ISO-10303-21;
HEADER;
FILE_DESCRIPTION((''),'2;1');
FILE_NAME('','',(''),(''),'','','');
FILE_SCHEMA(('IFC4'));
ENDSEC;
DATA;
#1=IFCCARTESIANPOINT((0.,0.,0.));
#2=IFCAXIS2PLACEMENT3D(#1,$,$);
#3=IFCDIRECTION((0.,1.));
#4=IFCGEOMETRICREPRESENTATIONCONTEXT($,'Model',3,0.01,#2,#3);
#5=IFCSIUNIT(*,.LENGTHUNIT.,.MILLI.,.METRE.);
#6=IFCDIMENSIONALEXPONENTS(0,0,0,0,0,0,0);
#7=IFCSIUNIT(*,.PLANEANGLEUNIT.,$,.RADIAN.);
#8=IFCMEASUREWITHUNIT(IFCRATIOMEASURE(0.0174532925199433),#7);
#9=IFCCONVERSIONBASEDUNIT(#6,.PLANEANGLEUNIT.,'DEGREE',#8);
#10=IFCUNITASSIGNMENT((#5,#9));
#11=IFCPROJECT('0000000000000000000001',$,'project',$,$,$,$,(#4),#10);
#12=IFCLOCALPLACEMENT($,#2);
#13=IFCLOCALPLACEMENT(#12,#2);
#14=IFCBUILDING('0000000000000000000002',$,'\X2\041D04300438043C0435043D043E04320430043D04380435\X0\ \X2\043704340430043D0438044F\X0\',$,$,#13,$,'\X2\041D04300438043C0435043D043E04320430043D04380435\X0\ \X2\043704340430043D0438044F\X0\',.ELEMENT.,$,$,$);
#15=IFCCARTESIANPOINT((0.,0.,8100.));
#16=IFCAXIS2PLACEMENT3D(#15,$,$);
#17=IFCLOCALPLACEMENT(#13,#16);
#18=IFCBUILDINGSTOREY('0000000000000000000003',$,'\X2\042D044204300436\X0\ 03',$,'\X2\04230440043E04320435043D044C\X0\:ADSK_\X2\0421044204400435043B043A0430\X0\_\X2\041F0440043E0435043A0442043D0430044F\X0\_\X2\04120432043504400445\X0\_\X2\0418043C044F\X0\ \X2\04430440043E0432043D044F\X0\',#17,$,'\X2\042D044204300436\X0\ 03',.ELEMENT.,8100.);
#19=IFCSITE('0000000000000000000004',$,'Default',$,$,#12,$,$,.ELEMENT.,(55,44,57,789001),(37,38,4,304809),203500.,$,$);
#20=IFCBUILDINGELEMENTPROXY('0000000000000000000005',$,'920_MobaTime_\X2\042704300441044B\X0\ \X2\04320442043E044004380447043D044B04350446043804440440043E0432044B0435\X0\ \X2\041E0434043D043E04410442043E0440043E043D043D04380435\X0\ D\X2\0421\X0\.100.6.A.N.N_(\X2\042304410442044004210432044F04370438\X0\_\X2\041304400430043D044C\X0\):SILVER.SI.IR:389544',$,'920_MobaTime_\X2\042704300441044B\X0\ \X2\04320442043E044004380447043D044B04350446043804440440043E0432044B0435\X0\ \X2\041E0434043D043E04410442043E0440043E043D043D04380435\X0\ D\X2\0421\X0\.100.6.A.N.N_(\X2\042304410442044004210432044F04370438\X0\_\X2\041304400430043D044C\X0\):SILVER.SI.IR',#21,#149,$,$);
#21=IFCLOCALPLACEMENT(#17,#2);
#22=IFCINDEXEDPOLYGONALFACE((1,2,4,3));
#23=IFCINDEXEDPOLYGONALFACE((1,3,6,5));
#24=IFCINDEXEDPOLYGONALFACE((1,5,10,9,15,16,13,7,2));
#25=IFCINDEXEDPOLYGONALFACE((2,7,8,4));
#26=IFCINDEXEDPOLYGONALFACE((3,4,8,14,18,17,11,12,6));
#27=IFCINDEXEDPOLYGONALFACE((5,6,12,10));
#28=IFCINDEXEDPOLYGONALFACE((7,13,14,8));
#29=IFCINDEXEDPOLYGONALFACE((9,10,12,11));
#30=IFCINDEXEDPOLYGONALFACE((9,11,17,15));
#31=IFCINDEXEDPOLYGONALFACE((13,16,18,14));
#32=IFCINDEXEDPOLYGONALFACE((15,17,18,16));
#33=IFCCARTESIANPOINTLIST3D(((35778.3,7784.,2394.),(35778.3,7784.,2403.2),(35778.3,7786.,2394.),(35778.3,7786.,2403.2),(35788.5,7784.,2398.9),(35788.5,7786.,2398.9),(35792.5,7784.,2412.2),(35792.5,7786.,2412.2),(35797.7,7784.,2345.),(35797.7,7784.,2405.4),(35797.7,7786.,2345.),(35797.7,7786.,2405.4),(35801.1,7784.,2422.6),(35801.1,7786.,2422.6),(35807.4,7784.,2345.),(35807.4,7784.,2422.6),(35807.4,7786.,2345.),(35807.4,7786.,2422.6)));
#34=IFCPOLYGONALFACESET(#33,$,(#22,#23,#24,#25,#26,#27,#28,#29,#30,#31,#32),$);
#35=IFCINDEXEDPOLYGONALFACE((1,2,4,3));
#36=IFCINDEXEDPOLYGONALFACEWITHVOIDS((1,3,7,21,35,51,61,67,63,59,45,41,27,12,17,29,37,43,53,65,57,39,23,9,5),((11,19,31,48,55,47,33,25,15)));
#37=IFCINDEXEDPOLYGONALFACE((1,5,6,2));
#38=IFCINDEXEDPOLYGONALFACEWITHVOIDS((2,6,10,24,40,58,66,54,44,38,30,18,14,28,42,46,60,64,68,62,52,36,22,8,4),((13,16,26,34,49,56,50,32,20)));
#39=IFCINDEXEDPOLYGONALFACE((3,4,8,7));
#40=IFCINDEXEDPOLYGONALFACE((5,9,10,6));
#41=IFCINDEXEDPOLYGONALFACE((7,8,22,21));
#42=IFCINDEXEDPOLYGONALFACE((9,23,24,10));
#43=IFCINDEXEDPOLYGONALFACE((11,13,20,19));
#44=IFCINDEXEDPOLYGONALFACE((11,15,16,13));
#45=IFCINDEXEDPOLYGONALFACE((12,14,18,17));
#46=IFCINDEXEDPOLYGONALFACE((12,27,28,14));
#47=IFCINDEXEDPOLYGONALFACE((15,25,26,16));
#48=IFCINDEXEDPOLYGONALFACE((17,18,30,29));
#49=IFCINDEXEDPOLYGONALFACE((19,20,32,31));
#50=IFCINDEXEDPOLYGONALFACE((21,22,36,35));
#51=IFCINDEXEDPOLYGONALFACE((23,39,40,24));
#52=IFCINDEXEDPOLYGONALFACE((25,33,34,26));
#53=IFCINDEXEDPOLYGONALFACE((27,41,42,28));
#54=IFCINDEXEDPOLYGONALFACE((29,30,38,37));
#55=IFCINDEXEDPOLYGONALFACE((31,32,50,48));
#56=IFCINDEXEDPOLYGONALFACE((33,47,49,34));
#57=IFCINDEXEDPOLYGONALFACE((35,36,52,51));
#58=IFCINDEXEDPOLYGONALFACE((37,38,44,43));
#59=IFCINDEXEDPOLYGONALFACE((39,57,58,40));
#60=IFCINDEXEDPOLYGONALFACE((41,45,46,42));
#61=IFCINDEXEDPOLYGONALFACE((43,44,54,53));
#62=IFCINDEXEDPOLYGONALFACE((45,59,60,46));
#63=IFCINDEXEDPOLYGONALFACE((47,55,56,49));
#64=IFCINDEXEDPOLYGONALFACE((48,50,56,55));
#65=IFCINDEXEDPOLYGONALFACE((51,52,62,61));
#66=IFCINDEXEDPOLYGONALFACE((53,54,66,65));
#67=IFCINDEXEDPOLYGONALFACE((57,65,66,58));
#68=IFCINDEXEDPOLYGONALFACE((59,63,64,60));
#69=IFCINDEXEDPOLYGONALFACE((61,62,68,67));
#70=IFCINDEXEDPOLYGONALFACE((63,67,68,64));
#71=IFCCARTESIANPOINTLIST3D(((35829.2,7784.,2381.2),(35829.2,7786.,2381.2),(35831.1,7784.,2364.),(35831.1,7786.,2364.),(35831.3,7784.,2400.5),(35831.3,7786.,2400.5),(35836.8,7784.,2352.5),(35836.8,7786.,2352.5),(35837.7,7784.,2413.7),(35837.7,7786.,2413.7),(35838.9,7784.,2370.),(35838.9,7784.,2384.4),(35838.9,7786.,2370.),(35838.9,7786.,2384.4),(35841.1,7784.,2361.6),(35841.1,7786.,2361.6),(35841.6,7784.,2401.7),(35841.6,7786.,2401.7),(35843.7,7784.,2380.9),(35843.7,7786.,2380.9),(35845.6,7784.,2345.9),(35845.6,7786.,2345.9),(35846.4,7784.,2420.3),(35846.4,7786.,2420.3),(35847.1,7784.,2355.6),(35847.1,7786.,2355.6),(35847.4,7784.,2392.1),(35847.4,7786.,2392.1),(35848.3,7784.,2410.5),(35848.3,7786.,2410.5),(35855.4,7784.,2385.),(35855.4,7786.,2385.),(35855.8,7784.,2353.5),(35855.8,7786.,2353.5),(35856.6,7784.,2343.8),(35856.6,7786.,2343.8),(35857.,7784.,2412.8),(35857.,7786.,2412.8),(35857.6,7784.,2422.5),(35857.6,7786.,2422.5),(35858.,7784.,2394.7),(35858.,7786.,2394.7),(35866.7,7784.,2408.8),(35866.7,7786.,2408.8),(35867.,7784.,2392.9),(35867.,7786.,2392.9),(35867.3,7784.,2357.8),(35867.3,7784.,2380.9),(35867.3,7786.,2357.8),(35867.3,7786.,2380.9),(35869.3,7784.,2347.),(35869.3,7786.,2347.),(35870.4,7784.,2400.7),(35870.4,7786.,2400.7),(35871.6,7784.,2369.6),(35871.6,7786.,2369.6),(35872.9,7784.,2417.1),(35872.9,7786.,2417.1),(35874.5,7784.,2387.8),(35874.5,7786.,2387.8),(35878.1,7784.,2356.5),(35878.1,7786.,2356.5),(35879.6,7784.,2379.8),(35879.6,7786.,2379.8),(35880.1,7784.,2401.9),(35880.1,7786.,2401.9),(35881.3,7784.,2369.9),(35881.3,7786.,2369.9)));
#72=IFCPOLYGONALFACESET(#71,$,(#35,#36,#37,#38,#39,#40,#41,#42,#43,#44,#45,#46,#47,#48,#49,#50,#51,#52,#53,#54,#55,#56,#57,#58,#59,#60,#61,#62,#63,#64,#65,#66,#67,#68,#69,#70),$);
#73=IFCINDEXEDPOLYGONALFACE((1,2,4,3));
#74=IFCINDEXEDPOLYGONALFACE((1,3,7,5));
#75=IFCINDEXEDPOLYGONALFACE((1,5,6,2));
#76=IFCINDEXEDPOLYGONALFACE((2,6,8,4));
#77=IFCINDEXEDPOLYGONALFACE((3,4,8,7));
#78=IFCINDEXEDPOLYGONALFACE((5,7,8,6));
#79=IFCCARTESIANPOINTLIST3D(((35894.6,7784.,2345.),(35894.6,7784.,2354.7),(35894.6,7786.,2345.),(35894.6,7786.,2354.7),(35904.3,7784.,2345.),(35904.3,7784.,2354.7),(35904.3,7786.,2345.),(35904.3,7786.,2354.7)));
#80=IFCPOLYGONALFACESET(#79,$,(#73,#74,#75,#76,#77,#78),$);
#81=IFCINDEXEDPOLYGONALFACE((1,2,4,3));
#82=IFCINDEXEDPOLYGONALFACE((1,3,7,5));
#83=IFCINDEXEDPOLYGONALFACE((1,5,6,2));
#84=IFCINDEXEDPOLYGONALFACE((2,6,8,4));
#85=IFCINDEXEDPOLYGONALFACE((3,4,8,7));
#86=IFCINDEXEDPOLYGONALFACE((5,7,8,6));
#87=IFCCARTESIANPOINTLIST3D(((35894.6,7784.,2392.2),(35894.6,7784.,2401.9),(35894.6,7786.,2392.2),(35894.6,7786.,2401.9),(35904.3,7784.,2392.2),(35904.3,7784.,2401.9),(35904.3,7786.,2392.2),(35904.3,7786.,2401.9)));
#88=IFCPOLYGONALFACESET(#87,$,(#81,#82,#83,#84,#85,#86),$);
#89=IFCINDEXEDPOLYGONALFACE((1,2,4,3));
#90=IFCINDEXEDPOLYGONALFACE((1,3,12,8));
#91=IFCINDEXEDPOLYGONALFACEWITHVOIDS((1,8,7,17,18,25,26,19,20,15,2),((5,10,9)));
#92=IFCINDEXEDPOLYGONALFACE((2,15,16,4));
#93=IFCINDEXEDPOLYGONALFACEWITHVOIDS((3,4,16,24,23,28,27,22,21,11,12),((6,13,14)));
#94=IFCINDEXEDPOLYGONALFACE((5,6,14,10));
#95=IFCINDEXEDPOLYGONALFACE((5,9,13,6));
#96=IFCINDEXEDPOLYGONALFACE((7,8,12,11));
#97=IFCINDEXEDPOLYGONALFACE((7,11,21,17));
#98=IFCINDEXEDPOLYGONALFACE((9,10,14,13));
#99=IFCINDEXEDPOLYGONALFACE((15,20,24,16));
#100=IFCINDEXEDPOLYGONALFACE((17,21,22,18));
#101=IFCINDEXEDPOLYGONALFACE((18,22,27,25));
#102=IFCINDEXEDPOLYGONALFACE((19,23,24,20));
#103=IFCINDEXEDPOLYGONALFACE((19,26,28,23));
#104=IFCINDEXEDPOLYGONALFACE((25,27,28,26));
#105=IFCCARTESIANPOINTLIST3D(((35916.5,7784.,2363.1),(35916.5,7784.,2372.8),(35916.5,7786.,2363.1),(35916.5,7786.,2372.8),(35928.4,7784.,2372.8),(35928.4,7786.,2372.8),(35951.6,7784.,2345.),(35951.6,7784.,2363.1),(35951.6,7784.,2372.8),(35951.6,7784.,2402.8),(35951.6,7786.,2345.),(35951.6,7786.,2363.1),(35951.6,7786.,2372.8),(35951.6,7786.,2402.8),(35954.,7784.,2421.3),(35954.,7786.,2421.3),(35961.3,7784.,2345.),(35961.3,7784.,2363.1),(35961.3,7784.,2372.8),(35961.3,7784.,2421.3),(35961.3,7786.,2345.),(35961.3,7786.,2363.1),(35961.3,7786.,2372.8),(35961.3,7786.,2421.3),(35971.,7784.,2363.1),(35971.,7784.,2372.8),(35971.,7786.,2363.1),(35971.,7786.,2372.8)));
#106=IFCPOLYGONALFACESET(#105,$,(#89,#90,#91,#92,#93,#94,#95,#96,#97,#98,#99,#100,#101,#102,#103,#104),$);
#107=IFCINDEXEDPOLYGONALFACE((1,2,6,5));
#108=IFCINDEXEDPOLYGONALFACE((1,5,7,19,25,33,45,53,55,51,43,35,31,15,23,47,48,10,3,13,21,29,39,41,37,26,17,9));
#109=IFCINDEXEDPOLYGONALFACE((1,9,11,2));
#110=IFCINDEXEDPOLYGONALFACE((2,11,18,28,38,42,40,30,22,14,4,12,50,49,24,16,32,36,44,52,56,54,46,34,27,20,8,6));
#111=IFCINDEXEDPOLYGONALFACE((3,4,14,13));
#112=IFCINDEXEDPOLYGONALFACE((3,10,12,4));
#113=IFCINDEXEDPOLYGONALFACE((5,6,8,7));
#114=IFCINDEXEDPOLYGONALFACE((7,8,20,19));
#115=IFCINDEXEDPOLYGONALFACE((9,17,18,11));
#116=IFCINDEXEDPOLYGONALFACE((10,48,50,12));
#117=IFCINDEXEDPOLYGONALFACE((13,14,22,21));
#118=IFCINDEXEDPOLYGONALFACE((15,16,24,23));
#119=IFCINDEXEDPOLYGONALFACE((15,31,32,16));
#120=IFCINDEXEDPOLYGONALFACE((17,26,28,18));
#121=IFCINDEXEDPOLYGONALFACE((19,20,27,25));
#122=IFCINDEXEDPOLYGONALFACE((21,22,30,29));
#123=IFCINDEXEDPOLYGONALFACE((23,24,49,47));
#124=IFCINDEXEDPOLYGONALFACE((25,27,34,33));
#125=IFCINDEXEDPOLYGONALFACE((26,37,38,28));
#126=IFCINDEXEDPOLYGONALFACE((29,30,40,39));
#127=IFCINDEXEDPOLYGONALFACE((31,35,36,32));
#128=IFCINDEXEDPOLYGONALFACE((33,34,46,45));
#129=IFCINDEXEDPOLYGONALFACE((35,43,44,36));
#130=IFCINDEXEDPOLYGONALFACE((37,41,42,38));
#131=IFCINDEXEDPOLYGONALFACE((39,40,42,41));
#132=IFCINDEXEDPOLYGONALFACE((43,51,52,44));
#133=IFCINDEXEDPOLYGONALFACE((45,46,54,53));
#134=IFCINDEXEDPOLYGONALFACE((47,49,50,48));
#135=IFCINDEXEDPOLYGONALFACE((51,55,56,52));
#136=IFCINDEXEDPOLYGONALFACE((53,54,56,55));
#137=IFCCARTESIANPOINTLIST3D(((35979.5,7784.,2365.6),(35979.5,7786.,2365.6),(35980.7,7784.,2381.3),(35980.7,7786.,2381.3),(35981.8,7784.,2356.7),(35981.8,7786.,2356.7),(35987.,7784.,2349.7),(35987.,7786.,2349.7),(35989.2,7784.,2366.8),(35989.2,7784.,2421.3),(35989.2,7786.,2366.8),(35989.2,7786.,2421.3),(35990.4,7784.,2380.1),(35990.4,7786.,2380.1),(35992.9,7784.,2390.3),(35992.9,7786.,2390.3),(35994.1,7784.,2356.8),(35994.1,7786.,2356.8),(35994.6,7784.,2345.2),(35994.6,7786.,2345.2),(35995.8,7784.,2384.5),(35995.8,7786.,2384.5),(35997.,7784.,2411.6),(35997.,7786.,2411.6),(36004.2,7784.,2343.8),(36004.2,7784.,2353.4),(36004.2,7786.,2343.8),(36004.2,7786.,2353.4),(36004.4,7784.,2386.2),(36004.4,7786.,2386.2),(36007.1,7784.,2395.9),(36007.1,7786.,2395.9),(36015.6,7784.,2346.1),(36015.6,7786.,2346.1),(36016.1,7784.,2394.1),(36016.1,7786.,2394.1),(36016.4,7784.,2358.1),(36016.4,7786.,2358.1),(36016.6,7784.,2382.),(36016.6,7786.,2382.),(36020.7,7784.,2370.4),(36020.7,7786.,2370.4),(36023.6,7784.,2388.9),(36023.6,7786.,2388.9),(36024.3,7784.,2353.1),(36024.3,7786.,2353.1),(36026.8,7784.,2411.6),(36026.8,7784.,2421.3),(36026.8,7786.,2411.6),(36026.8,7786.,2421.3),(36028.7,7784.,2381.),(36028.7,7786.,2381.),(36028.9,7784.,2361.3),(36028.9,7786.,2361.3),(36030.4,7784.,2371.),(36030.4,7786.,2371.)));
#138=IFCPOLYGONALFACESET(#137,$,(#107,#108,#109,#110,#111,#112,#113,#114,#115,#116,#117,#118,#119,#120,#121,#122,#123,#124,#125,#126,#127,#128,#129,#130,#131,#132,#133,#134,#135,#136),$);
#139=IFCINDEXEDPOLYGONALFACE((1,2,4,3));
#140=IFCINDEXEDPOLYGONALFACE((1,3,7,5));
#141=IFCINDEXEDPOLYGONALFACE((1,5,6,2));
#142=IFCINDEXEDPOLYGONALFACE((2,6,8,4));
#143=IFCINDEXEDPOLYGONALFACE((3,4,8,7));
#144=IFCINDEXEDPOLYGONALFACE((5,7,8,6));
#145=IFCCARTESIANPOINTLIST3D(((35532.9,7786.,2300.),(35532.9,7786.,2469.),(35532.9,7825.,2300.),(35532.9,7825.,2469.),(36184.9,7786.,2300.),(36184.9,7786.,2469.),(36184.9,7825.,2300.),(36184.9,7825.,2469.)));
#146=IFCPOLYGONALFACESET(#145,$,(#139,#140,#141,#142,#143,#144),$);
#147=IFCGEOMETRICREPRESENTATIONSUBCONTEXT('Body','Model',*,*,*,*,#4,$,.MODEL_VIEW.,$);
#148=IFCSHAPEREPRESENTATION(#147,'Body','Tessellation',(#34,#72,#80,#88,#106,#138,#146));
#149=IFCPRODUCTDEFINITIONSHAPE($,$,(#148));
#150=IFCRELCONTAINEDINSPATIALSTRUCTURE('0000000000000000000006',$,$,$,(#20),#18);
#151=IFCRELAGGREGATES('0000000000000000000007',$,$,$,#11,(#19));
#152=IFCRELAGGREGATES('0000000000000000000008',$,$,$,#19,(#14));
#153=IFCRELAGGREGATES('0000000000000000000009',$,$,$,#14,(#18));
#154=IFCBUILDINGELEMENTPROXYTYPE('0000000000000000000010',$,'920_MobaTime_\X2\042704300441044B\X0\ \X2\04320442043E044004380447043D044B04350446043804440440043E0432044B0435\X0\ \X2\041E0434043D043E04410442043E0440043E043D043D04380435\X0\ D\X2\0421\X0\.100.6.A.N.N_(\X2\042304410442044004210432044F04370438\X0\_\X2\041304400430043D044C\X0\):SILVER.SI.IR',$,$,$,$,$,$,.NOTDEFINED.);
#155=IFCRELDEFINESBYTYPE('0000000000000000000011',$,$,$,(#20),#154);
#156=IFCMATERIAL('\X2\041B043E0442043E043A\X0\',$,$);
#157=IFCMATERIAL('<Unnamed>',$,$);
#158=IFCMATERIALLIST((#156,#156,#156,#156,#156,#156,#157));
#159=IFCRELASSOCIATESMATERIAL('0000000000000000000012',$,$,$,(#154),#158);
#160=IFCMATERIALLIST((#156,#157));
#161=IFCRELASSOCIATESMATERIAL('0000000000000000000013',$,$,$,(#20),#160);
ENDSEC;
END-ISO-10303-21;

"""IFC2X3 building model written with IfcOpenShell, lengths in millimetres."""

from ifc_helpers import new_model, entity, si_unit, converted_unit, direction, frame, origin, origin_2d_with_axis, place, context, subcontext, project, spatial, polyline, rectangle, outline, extrude, source, transform, mapped, material, material_list, type_object, type_shapes, element, save


model = new_model("IFC2X3")

# Units and contexts
model_context = context("Model", 3, precision=0.01, world=origin(), true_north=direction((0.0, 1.0)))
body_context = subcontext(model_context, "Body", "Model", "MODEL_VIEW")
ifc_project = project(units=[si_unit("LENGTHUNIT", "METRE", prefix="MILLI"), converted_unit("PLANEANGLEUNIT", "DEGREE", entity("IfcRatioMeasure", 0.0174532925199433), si_unit("PLANEANGLEUNIT", "RADIAN"), dimensions=[0, 0, 0, 0, 0, 0, 0])], contexts=[model_context])

# Site, building, storey
site_placement = place(None, origin())
site = spatial("IfcSite", under=ifc_project, at=site_placement, Name="Default", CompositionType="ELEMENT", RefLatitude=(55, 44, 57, 789001), RefLongitude=(37, 38, 4, 304809), RefElevation=203500.0)
building_placement = place(site_placement, origin())
building = spatial("IfcBuilding", under=site, at=building_placement, Name="Наименование здания", LongName="Наименование здания", CompositionType="ELEMENT")
storey_placement = place(building_placement, frame((0.0, 0.0, 8100.0)))
storey = spatial("IfcBuildingStorey", under=building, at=storey_placement, Name="Этаж 03", ObjectType="Уровень:ADSK_Стрелка_Проектная_Вверх_Имя уровня", LongName="Этаж 03", CompositionType="ELEMENT", Elevation=8100.0)

# Building element proxy
ifc_material_1 = material(Name="Лоток")
ifc_material_2 = material(Name="<Unnamed>")
ifc_material_list_1 = material_list([ifc_material_1, ifc_material_1, ifc_material_1, ifc_material_1, ifc_material_1, ifc_material_1, ifc_material_2])
building_element_proxy_type = type_object("IfcBuildingElementProxyType", Name="920_MobaTime_Часы вторичныецифровые Односторонние DС.100.6.A.N.N_(УстрСвязи_Грань):SILVER.SI.IR", PredefinedType="NOTDEFINED", material=ifc_material_list_1)
shared_shape = source(origin(), body_context, "Body", "SweptSolid", [
    extrude(outline(polyline([(-49.3, -13.1), (28.2, -13.1), (28.2, -6.8), (17.9, 1.8), (8.8, 16.0), (-0.3, 16.0), (4.6, 5.8), (11.1, -3.4), (-49.3, -3.4), (-49.3, -13.1)])), frame((-64.6, 9.8, 39.0), z_axis=(0.0, 0.0, 1.0), x_axis=(0.0, 1.0, 0.0)), (0.0, 0.0, 1.0), 2.0),
    extrude(outline(polyline([(2.2, -27.6), (19.0, -27.6), (30.5, -16.1), (33.3, -4.9), (31.0, 5.8), (21.8, 17.2), (5.2, 27.3), (-11.1, 33.0), (-24.0, 32.7), (-33.6, 27.6), (-40.3, 18.6), (-42.8, 5.7), (-38.0, -6.3), (-27.2, -14.9), (-17.5, -17.7), (-8.2, -16.4), (-0.3, -11.9), (5.1, -4.5), (7.3, 6.2), (4.0, 17.2), (18.4, 7.3), (23.6, -2.4), (22.0, -11.4), (14.2, -18.4), (5.3, -18.3), (2.2, -27.6)]), holes=[polyline([(-9.0, 23.3), (-1.3, 14.3), (-2.5, 2.0), (-11.4, -7.0), (-23.4, -6.0), (-32.2, 2.9), (-31.2, 15.1), (-25.6, 22.1), (-17.5, 24.9), (-9.0, 23.3)])]), frame((-2.7, 3.6, 39.0), z_axis=(0.0, 0.0, 1.0), x_axis=(-0.427649, 0.903945, 0.0)), (0.0, 0.0, 1.0), 2.0),
    extrude(rectangle(XDim=9.7, YDim=9.7, at=origin_2d_with_axis()), frame((40.6, -34.7, 39.0)), (0.0, 0.0, 1.0), 2.0),
    extrude(rectangle(XDim=9.7, YDim=9.7, at=origin_2d_with_axis()), frame((40.6, 12.6, 39.0)), (0.0, 0.0, 1.0), 2.0),
    extrude(outline(polyline([(-0.9, -28.1), (8.8, -28.1), (8.8, -9.9), (18.5, -9.9), (18.5, -0.2), (8.8, -0.2), (8.8, 48.3), (1.5, 48.3), (-36.0, -0.2), (-36.0, -9.9), (-0.9, -9.9), (-0.9, -28.1)]), holes=[polyline([(-0.9, -0.2), (-24.1, -0.2), (-0.9, 29.7), (-0.9, -0.2)])]), frame((93.6, -11.4, 39.0)), (0.0, 0.0, 1.0), 2.0),
    extrude(outline(polyline([(3.3, -28.3), (12.5, -28.3), (20.5, -25.0), (26.8, -18.9), (30.7, -10.0), (31.4, 1.6), (26.9, 11.8), (20.1, 18.4), (11.1, 22.3), (1.0, 23.3), (-7.9, 20.4), (-14.9, 14.5), (-18.9, 6.2), (-17.1, -9.0), (-36.7, 0.5), (-29.1, 29.2), (-38.5, 31.7), (-48.1, -4.6), (-11.6, -23.1), (-8.0, -14.0), (-10.8, -7.6), (-10.2, 1.1), (-3.0, 11.8), (9.2, 12.8), (20.0, 5.5), (21.4, -7.5), (15.5, -16.4), (4.6, -18.6), (3.3, -28.3)])), frame((147.1, -8.5, 39.0), z_axis=(0.0, 0.0, 1.0), x_axis=(0.256974, -0.966418, 0.0)), (0.0, 0.0, 1.0), 2.0),
    extrude(rectangle(XDim=652.0, YDim=169.0, at=origin_2d_with_axis()), frame((0.0, 0.0, 0.0), z_axis=(0.0, 0.0, 1.0), x_axis=(-1.0, 0.0, 0.0)), (0.0, 0.0, 1.0), 39.0),
])
type_shapes(building_element_proxy_type, [shared_shape])
ifc_material_list_2 = material_list([ifc_material_1, ifc_material_2])
for number, where, z_axis, x_axis, name in (
    (1, (35858.9, 7825.0, 2384.5), (0.0, -1.0, 0.0), (1.0, 0.0, 0.0), "920_MobaTime_Часы вторичныецифровые Односторонние DС.100.6.A.N.N_(УстрСвязи_Грань):SILVER.SI.IR:389544"),
):
    element("IfcBuildingElementProxy", number, at=place(storey_placement, frame(where, z_axis=z_axis, x_axis=x_axis)), inside=storey, type_object=building_element_proxy_type, material=ifc_material_list_2, Name=name, ObjectType="920_MobaTime_Часы вторичныецифровые Односторонние DС.100.6.A.N.N_(УстрСвязи_Грань):SILVER.SI.IR", context=body_context, shape_type="MappedRepresentation", body=[
        mapped(shared_shape, transform((0.0, 0.0, 0.0), scale=1.0)),
    ])

save(model, "model.ifc")
